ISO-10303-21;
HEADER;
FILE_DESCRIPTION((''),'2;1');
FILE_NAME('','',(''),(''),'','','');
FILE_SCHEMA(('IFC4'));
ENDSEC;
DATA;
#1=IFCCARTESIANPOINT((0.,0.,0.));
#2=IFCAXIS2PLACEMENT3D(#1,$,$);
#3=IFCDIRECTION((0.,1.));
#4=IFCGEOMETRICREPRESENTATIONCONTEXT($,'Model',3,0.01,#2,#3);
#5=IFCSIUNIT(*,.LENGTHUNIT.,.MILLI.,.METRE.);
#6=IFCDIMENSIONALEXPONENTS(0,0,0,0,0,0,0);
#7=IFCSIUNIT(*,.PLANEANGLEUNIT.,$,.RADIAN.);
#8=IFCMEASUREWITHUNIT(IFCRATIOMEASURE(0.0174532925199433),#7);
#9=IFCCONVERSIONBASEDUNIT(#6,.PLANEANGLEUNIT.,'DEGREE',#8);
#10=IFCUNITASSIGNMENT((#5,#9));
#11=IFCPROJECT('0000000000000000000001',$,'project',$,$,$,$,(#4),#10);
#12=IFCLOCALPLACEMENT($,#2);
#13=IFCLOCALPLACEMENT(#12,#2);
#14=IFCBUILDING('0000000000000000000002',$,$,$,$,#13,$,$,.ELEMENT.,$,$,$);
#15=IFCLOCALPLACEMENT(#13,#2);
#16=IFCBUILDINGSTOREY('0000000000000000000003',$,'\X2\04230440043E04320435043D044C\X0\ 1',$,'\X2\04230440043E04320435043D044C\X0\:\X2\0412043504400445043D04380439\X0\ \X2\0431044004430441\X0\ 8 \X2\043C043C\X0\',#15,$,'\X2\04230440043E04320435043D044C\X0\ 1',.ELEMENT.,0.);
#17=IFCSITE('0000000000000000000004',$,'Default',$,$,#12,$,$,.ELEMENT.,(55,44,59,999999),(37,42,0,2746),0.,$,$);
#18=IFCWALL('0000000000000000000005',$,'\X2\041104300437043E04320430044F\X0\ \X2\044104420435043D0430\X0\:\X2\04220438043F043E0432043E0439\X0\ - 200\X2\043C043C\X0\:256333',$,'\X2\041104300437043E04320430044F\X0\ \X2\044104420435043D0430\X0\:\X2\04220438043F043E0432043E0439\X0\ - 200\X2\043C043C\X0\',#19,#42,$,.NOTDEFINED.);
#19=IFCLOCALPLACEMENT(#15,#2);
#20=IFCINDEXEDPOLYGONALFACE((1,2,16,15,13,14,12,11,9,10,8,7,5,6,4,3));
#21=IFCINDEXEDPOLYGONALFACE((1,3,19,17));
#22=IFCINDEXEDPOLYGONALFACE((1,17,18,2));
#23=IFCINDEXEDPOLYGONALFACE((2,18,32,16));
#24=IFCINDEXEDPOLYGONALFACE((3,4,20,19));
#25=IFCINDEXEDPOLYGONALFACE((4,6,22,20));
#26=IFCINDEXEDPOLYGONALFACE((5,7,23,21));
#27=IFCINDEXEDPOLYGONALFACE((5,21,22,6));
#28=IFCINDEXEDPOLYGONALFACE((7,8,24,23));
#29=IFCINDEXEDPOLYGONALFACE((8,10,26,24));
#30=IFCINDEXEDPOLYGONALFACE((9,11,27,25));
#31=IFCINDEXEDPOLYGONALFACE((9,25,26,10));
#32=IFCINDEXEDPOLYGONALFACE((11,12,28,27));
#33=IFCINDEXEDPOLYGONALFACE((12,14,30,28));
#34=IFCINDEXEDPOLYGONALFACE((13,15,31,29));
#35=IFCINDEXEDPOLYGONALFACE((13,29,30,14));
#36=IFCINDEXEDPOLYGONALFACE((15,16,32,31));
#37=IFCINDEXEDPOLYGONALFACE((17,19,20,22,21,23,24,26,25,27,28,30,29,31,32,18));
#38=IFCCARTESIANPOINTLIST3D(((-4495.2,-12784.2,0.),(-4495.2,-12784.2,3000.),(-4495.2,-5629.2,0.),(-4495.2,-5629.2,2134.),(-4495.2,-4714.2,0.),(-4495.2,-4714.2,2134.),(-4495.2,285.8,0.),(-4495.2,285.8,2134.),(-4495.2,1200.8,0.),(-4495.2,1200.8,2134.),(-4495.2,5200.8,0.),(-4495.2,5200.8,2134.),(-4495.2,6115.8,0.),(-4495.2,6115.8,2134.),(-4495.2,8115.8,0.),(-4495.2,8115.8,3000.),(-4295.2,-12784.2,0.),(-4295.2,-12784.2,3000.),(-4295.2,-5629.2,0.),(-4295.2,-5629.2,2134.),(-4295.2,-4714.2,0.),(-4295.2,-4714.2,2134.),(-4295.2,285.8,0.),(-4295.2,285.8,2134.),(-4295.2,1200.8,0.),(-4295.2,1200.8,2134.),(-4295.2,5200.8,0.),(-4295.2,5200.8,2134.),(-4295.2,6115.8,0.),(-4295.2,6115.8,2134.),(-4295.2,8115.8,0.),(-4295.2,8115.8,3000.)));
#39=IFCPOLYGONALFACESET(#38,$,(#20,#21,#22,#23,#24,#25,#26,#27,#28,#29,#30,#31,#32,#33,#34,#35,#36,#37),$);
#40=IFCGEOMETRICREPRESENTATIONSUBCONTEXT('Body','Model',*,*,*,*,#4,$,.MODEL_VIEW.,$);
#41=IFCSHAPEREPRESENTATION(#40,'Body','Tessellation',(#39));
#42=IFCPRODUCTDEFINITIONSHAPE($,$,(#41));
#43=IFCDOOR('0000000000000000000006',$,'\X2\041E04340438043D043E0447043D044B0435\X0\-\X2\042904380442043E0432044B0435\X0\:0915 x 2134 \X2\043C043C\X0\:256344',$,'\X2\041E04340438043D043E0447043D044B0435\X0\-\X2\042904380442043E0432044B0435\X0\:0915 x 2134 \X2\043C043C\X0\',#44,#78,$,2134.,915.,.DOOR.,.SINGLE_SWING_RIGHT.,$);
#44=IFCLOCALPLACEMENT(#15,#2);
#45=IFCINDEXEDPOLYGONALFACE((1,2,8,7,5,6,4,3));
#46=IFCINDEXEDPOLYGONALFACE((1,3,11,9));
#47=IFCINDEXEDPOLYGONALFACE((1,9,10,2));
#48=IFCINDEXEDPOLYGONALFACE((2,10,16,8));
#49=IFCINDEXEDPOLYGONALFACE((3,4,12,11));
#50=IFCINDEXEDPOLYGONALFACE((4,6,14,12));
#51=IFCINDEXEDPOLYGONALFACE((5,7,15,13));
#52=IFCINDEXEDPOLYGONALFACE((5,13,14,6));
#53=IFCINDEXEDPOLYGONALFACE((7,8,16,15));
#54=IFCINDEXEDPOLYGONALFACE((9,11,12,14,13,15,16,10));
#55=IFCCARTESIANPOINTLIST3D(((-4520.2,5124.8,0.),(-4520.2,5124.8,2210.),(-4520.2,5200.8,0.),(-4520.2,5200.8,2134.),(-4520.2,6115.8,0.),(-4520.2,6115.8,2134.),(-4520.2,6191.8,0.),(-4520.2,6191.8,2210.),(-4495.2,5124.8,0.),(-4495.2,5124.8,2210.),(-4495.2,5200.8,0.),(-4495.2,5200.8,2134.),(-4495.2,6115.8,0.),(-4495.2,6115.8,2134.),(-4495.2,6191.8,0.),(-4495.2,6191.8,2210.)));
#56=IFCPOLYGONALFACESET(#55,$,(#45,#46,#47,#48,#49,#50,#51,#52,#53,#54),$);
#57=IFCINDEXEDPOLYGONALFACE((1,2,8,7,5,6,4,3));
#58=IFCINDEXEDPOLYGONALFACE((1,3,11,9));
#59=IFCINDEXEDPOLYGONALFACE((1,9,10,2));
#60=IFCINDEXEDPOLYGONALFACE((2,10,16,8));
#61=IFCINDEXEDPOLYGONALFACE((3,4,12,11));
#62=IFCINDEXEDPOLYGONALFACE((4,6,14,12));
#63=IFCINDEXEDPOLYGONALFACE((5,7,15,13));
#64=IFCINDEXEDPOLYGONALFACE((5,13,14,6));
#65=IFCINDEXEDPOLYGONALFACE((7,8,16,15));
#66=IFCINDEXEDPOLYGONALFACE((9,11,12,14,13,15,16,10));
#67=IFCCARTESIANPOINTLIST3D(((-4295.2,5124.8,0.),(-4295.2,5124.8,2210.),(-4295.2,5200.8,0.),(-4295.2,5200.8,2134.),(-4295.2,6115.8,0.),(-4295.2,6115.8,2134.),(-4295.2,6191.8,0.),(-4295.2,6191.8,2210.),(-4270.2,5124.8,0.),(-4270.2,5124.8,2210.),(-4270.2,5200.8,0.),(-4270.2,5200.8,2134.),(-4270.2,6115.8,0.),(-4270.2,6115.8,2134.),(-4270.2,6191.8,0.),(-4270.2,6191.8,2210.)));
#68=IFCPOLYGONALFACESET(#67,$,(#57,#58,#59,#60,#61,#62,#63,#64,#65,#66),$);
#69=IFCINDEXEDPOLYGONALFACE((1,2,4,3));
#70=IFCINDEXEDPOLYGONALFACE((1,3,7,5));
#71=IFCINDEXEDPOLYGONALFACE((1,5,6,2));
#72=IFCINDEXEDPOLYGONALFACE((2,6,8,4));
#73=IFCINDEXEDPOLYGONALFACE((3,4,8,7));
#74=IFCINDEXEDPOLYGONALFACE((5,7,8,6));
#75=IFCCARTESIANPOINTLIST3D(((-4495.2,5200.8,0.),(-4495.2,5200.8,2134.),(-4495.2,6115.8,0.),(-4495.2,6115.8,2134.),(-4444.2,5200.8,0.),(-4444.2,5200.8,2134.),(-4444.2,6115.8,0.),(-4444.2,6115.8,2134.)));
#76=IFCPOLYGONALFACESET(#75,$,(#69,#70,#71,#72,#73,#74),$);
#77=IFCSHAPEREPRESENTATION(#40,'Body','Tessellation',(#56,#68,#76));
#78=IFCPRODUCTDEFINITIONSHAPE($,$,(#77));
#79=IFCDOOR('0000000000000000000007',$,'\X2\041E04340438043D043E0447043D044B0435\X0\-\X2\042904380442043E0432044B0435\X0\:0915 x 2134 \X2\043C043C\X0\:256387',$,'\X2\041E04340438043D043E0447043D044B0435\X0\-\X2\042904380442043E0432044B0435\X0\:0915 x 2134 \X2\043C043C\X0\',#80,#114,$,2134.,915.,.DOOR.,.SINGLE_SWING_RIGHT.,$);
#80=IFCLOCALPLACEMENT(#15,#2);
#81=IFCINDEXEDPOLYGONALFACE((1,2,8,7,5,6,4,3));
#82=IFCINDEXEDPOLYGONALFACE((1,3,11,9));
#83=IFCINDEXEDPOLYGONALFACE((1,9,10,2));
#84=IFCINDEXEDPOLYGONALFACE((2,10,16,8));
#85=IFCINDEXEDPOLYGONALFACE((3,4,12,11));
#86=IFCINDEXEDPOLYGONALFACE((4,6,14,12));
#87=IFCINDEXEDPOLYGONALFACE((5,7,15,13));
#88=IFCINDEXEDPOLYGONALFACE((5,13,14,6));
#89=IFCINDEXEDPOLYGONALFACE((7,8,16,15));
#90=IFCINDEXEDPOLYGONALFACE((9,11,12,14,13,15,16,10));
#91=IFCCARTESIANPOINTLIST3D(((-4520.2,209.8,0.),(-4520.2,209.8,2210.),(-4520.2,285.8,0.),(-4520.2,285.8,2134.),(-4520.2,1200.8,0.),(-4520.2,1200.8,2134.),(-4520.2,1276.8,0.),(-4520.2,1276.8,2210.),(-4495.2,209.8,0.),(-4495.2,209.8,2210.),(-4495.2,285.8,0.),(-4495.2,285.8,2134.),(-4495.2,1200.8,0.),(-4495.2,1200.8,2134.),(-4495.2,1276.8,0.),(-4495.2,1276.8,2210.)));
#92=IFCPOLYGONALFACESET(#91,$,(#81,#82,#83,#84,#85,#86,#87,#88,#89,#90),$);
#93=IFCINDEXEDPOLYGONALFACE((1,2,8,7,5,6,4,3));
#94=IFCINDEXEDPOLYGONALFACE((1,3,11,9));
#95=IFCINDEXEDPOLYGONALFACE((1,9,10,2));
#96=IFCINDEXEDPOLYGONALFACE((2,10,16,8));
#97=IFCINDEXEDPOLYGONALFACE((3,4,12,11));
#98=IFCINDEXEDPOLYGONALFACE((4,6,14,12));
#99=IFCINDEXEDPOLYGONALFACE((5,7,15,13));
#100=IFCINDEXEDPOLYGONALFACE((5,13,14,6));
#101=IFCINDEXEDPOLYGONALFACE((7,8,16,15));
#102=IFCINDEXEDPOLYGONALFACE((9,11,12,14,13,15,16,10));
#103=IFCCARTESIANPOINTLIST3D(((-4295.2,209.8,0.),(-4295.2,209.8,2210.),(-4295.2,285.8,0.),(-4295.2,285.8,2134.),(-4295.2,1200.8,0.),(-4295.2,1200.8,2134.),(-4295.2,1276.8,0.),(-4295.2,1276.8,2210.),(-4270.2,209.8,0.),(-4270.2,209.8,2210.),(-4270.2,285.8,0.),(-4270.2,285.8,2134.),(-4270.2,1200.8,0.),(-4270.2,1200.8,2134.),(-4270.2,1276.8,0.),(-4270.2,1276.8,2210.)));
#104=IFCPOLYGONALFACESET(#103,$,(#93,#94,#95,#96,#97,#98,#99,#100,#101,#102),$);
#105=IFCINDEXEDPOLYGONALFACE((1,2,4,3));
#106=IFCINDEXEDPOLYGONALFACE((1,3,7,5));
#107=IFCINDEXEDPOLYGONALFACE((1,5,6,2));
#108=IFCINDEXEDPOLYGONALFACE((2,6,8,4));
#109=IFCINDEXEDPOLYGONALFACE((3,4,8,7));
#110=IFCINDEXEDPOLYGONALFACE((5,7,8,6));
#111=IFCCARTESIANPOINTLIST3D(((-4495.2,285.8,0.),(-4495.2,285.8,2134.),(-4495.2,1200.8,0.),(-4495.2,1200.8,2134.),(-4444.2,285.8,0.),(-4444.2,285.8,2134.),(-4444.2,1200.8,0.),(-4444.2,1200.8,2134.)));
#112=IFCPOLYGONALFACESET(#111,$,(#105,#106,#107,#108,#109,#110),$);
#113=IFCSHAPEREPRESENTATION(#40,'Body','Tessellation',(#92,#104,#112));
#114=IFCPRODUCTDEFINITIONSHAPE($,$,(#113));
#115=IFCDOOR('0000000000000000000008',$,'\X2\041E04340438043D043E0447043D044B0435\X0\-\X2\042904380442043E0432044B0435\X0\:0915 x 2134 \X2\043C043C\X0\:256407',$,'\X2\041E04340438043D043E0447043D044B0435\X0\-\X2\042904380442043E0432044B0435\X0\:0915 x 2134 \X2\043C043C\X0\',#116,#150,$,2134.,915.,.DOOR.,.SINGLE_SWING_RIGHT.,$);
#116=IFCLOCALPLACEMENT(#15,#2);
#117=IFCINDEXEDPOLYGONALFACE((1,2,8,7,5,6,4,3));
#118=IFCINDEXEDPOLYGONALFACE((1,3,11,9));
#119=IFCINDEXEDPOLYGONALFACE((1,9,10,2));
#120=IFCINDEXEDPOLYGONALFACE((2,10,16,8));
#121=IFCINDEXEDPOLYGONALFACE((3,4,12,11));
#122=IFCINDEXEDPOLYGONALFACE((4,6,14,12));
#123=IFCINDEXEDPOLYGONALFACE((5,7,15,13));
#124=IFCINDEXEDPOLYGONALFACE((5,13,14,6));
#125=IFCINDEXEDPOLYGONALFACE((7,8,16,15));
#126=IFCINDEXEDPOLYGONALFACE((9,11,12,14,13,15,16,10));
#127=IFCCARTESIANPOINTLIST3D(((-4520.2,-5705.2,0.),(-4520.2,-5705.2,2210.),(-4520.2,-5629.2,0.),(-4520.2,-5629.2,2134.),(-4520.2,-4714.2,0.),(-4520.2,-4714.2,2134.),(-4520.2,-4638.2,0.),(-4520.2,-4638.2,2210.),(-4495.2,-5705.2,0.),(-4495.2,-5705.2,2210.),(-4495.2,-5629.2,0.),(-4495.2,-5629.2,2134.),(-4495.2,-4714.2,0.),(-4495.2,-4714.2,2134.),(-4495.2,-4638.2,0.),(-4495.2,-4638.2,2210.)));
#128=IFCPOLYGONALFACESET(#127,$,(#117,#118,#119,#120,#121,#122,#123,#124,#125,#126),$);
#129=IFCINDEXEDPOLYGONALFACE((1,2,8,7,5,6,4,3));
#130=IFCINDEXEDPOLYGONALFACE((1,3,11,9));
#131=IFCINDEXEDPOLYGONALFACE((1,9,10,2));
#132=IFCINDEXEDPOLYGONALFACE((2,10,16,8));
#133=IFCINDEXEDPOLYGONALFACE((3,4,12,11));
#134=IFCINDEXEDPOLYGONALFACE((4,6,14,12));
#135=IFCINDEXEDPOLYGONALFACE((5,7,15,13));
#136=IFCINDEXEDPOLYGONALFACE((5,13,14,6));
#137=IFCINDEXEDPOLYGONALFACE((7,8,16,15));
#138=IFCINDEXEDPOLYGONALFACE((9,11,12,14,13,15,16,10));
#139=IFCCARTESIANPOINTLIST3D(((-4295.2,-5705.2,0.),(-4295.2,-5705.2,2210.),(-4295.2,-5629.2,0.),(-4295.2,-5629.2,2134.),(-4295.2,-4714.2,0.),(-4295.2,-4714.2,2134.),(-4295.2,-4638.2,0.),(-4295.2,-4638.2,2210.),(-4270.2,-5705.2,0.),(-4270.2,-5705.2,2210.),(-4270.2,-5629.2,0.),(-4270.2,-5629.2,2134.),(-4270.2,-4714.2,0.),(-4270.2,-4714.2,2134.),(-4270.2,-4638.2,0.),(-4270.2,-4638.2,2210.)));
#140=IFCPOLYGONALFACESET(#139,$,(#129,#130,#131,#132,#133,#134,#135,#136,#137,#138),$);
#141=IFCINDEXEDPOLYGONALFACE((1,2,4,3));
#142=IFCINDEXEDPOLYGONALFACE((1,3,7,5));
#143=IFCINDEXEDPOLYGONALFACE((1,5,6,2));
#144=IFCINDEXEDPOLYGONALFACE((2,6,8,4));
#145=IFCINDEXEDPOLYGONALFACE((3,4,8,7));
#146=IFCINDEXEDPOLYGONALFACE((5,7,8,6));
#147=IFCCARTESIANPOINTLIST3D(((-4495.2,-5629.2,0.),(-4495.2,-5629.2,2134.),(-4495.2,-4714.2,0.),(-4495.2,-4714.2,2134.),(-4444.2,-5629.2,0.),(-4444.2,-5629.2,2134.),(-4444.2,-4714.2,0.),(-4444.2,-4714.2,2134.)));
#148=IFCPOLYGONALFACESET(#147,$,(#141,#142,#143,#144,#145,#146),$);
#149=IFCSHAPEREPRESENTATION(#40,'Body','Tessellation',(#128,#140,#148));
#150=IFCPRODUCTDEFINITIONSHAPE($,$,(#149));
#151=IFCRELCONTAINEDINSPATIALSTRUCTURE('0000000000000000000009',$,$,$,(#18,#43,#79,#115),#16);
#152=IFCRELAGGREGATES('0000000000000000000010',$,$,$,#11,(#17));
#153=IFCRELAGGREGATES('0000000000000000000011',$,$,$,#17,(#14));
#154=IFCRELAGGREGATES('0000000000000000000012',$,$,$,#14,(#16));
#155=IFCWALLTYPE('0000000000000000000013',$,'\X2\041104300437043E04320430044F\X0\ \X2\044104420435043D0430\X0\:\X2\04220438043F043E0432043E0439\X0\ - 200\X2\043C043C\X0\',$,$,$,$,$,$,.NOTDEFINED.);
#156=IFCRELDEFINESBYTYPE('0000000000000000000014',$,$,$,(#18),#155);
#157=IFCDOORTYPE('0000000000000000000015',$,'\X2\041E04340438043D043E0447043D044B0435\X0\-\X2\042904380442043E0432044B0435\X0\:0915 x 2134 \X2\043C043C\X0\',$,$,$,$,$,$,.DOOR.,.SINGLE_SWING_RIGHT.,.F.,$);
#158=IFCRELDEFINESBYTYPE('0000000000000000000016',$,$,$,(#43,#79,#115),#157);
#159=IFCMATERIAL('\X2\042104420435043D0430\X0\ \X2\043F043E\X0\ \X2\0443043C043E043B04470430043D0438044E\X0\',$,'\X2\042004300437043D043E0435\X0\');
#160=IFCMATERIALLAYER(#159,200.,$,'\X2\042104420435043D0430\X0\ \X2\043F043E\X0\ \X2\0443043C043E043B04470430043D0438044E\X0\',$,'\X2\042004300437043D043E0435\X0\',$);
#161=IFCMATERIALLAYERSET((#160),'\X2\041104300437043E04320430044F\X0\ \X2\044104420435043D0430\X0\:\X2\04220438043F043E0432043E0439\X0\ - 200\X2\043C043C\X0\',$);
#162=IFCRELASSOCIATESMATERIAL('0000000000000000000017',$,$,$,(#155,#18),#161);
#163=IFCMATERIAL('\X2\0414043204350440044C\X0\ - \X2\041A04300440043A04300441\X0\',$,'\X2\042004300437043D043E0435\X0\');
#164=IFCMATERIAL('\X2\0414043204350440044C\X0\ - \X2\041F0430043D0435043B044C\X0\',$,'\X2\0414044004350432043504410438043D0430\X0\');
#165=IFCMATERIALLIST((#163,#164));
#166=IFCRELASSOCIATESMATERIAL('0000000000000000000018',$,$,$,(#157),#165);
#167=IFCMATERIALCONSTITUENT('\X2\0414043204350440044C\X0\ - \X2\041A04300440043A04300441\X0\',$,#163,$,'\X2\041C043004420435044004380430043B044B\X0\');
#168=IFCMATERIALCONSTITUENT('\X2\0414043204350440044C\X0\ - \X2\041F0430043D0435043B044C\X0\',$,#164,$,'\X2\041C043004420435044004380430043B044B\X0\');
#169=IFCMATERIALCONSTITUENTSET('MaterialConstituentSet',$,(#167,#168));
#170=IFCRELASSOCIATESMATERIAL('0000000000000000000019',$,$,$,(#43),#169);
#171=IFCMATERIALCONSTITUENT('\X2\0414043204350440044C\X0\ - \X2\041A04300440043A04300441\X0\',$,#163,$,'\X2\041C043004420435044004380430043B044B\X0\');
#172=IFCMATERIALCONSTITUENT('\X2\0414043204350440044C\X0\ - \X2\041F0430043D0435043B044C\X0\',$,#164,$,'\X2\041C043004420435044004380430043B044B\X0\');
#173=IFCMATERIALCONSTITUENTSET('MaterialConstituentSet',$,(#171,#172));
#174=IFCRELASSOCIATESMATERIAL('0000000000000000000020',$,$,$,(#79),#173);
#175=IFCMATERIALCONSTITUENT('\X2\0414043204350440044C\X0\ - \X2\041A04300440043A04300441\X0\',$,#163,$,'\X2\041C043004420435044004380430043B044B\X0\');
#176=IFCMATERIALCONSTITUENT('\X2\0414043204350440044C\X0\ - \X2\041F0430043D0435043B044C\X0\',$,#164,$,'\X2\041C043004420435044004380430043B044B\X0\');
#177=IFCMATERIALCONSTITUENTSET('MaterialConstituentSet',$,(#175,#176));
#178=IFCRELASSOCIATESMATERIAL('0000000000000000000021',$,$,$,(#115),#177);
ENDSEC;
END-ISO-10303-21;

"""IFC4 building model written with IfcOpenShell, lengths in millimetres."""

from ifc_helpers import new_model, entity, si_unit, converted_unit, direction, frame, frame_2d, origin, place, context, subcontext, project, spatial, polyline, rectangle, outline, extrude, source, transform, mapped, material, material_list, layer, layer_set, layer_usage, constituent, constituent_set, type_object, type_shapes, element, fill, save


model = new_model("IFC4")

# Units and contexts
model_context = context("Model", 3, precision=0.01, world=origin(), true_north=direction((0.0, 1.0)))
body_context = subcontext(model_context, "Body", "Model", "MODEL_VIEW")
ifc_project = project(units=[si_unit("LENGTHUNIT", "METRE", prefix="MILLI"), converted_unit("PLANEANGLEUNIT", "DEGREE", entity("IfcRatioMeasure", 0.0174532925199433), si_unit("PLANEANGLEUNIT", "RADIAN"), dimensions=[0, 0, 0, 0, 0, 0, 0])], contexts=[model_context])

# Site, building, storey
site_placement = place(None, origin())
site = spatial("IfcSite", under=ifc_project, at=site_placement, Name="Default", CompositionType="ELEMENT", RefLatitude=(55, 44, 59, 999999), RefLongitude=(37, 42, 0, 2746), RefElevation=0.0)
building_placement = place(site_placement, origin())
building = spatial("IfcBuilding", under=site, at=building_placement, CompositionType="ELEMENT")
storey_placement = place(building_placement, origin())
storey = spatial("IfcBuildingStorey", under=building, at=storey_placement, Name="Уровень 1", ObjectType="Уровень:Верхний брус 8 мм", LongName="Уровень 1", CompositionType="ELEMENT", Elevation=0.0)

# Shared definitions
ifc_material_1 = material(Name="Стена по умолчанию", Category="Разное")
ifc_layer_1 = layer(ifc_material_1, 200.0, Name="Стена по умолчанию", Category="Разное")
ifc_layer_set_1 = layer_set([ifc_layer_1], Name="Базовая стена:Типовой - 200мм")
wall_type = type_object("IfcWallType", Name="Базовая стена:Типовой - 200мм", PredefinedType="NOTDEFINED", material=ifc_layer_set_1)

# Shared definitions
ifc_material_2 = material(Name="Дверь - Каркас", Category="Разное")
ifc_material_3 = material(Name="Дверь - Панель", Category="Древесина")
ifc_material_list_1 = material_list([ifc_material_2, ifc_material_3])
door_type = type_object("IfcDoorType", Name="Одиночные-Щитовые:0915 x 2134 мм", OperationType="SINGLE_SWING_RIGHT", ParameterTakesPrecedence=False, PredefinedType="DOOR", material=ifc_material_list_1)
shared_shape_1 = source(origin(), body_context, "Body", "SweptSolid", [
    extrude(outline(polyline([(-533.5, -1124.0), (533.5, -1124.0), (533.5, 1086.0), (457.5, 1086.0), (457.5, -1048.0), (-457.5, -1048.0), (-457.5, 1086.0), (-533.5, 1086.0), (-533.5, -1124.0)])), frame((457.5, 200.0, 1086.0), z_axis=(0.0, 1.0, 0.0), x_axis=(1.0, 0.0, 0.0)), (0.0, 0.0, 1.0), 25.0),
    extrude(outline(polyline([(-1124.0, -533.5), (1086.0, -533.5), (1086.0, -457.5), (-1048.0, -457.5), (-1048.0, 457.5), (1086.0, 457.5), (1086.0, 533.5), (-1124.0, 533.5), (-1124.0, -533.5)])), frame((457.5, -25.0, 1086.0), z_axis=(0.0, 1.0, 0.0), x_axis=(0.0, 0.0, -1.0)), (0.0, 0.0, 1.0), 25.0),
    extrude(rectangle(XDim=51.0, YDim=915.0, at=frame_2d((0.0, 0.0), x_axis=(1.0, 0.0))), frame((457.5, 174.5, 0.0), z_axis=(0.0, 0.0, 1.0), x_axis=(0.0, 1.0, 0.0)), (0.0, 0.0, 1.0), 2134.0),
])
type_shapes(door_type, [shared_shape_1])

# Wall, openings, doors
ifc_layer_usage_1 = layer_usage(ifc_layer_set_1, "AXIS2", "NEGATIVE", 100.0)
wall_1_placement = place(storey_placement, frame((-4395.2, 8115.8, 0.0), z_axis=(0.0, 0.0, 1.0), x_axis=(0.0, -1.0, 0.0)))
wall_1 = element("IfcWall", 1, at=wall_1_placement, inside=storey, type_object=wall_type, material=ifc_layer_usage_1, Name="Базовая стена:Типовой - 200мм:256333", ObjectType="Базовая стена:Типовой - 200мм", PredefinedType="NOTDEFINED", context=body_context, shape_type="SweptSolid", body=[
    extrude(rectangle(XDim=20900.0, YDim=200.0, at=frame_2d((10450.0, 0.0), x_axis=(-1.0, 0.0))), origin(), (0.0, 0.0, 1.0), 3000.0),
])
opening_1_placement = place(wall_1_placement, frame((2915.0, 100.0, 0.0)))
opening_1 = element("IfcOpeningElement", 2, at=opening_1_placement, cuts=wall_1, ObjectType="Opening", PredefinedType="OPENING", context=body_context, shape_type="SweptSolid", body=[
    extrude(rectangle(XDim=915.0, YDim=2134.0, at=frame_2d((1067.0, 457.5), x_axis=(0.0, 1.0))), frame((0.0, 0.0, 0.0), z_axis=(0.0, -1.0, 0.0), x_axis=(0.0, 0.0, 1.0)), (0.0, 0.0, 1.0), 200.0),
])
opening_2_placement = place(wall_1_placement, frame((7830.0, 100.0, 0.0)))
opening_2 = element("IfcOpeningElement", 3, at=opening_2_placement, cuts=wall_1, ObjectType="Opening", PredefinedType="OPENING", context=body_context, shape_type="SweptSolid", body=[
    extrude(rectangle(XDim=915.0, YDim=2134.0, at=frame_2d((1067.0, 457.5), x_axis=(0.0, 1.0))), frame((0.0, 0.0, 0.0), z_axis=(0.0, -1.0, 0.0), x_axis=(0.0, 0.0, 1.0)), (0.0, 0.0, 1.0), 200.0),
])
opening_3_placement = place(wall_1_placement, frame((13745.0, 100.0, 0.0)))
opening_3 = element("IfcOpeningElement", 4, at=opening_3_placement, cuts=wall_1, ObjectType="Opening", PredefinedType="OPENING", context=body_context, shape_type="SweptSolid", body=[
    extrude(rectangle(XDim=915.0, YDim=2134.0, at=frame_2d((1067.0, 457.5), x_axis=(0.0, 1.0))), frame((0.0, 0.0, 0.0), z_axis=(0.0, -1.0, 0.0), x_axis=(0.0, 0.0, 1.0)), (0.0, 0.0, 1.0), 200.0),
])
ifc_constituent_1 = constituent(ifc_material_2, Name="Дверь - Каркас", Category="Материалы")
ifc_constituent_2 = constituent(ifc_material_3, Name="Дверь - Панель", Category="Материалы")
ifc_constituent_set_1 = constituent_set(constituents=[ifc_constituent_1, ifc_constituent_2], Name="MaterialConstituentSet")
door_1_placement = place(opening_1_placement, frame((0.0, 0.0, 0.0), z_axis=(0.0, 0.0, 1.0), x_axis=(-1.0, 0.0, 0.0)))
door_1 = element("IfcDoor", 5, at=door_1_placement, inside=storey, type_object=door_type, material=ifc_constituent_set_1, Name="Одиночные-Щитовые:0915 x 2134 мм:256344", ObjectType="Одиночные-Щитовые:0915 x 2134 мм", OperationType="SINGLE_SWING_RIGHT", OverallHeight=2134.0, OverallWidth=915.0, PredefinedType="DOOR", context=body_context, shape_type="MappedRepresentation", body=[
    mapped(shared_shape_1, transform((0.0, 0.0, 0.0), scale=1.0)),
])
fill(opening_1, door_1)
ifc_constituent_3 = constituent(ifc_material_2, Name="Дверь - Каркас", Category="Материалы")
ifc_constituent_4 = constituent(ifc_material_3, Name="Дверь - Панель", Category="Материалы")
ifc_constituent_set_2 = constituent_set(constituents=[ifc_constituent_3, ifc_constituent_4], Name="MaterialConstituentSet")
door_2_placement = place(opening_2_placement, frame((0.0, 0.0, 0.0), z_axis=(0.0, 0.0, 1.0), x_axis=(-1.0, 0.0, 0.0)))
door_2 = element("IfcDoor", 6, at=door_2_placement, inside=storey, type_object=door_type, material=ifc_constituent_set_2, Name="Одиночные-Щитовые:0915 x 2134 мм:256387", ObjectType="Одиночные-Щитовые:0915 x 2134 мм", OperationType="SINGLE_SWING_RIGHT", OverallHeight=2134.0, OverallWidth=915.0, PredefinedType="DOOR", context=body_context, shape_type="MappedRepresentation", body=[
    mapped(shared_shape_1, transform((0.0, 0.0, 0.0), scale=1.0)),
])
fill(opening_2, door_2)
ifc_constituent_5 = constituent(ifc_material_2, Name="Дверь - Каркас", Category="Материалы")
ifc_constituent_6 = constituent(ifc_material_3, Name="Дверь - Панель", Category="Материалы")
ifc_constituent_set_3 = constituent_set(constituents=[ifc_constituent_5, ifc_constituent_6], Name="MaterialConstituentSet")
door_3_placement = place(opening_3_placement, frame((0.0, 0.0, 0.0), z_axis=(0.0, 0.0, 1.0), x_axis=(-1.0, 0.0, 0.0)))
door_3 = element("IfcDoor", 7, at=door_3_placement, inside=storey, type_object=door_type, material=ifc_constituent_set_3, Name="Одиночные-Щитовые:0915 x 2134 мм:256407", ObjectType="Одиночные-Щитовые:0915 x 2134 мм", OperationType="SINGLE_SWING_RIGHT", OverallHeight=2134.0, OverallWidth=915.0, PredefinedType="DOOR", context=body_context, shape_type="MappedRepresentation", body=[
    mapped(shared_shape_1, transform((0.0, 0.0, 0.0), scale=1.0)),
])
fill(opening_3, door_3)

save(model, "model.ifc")
